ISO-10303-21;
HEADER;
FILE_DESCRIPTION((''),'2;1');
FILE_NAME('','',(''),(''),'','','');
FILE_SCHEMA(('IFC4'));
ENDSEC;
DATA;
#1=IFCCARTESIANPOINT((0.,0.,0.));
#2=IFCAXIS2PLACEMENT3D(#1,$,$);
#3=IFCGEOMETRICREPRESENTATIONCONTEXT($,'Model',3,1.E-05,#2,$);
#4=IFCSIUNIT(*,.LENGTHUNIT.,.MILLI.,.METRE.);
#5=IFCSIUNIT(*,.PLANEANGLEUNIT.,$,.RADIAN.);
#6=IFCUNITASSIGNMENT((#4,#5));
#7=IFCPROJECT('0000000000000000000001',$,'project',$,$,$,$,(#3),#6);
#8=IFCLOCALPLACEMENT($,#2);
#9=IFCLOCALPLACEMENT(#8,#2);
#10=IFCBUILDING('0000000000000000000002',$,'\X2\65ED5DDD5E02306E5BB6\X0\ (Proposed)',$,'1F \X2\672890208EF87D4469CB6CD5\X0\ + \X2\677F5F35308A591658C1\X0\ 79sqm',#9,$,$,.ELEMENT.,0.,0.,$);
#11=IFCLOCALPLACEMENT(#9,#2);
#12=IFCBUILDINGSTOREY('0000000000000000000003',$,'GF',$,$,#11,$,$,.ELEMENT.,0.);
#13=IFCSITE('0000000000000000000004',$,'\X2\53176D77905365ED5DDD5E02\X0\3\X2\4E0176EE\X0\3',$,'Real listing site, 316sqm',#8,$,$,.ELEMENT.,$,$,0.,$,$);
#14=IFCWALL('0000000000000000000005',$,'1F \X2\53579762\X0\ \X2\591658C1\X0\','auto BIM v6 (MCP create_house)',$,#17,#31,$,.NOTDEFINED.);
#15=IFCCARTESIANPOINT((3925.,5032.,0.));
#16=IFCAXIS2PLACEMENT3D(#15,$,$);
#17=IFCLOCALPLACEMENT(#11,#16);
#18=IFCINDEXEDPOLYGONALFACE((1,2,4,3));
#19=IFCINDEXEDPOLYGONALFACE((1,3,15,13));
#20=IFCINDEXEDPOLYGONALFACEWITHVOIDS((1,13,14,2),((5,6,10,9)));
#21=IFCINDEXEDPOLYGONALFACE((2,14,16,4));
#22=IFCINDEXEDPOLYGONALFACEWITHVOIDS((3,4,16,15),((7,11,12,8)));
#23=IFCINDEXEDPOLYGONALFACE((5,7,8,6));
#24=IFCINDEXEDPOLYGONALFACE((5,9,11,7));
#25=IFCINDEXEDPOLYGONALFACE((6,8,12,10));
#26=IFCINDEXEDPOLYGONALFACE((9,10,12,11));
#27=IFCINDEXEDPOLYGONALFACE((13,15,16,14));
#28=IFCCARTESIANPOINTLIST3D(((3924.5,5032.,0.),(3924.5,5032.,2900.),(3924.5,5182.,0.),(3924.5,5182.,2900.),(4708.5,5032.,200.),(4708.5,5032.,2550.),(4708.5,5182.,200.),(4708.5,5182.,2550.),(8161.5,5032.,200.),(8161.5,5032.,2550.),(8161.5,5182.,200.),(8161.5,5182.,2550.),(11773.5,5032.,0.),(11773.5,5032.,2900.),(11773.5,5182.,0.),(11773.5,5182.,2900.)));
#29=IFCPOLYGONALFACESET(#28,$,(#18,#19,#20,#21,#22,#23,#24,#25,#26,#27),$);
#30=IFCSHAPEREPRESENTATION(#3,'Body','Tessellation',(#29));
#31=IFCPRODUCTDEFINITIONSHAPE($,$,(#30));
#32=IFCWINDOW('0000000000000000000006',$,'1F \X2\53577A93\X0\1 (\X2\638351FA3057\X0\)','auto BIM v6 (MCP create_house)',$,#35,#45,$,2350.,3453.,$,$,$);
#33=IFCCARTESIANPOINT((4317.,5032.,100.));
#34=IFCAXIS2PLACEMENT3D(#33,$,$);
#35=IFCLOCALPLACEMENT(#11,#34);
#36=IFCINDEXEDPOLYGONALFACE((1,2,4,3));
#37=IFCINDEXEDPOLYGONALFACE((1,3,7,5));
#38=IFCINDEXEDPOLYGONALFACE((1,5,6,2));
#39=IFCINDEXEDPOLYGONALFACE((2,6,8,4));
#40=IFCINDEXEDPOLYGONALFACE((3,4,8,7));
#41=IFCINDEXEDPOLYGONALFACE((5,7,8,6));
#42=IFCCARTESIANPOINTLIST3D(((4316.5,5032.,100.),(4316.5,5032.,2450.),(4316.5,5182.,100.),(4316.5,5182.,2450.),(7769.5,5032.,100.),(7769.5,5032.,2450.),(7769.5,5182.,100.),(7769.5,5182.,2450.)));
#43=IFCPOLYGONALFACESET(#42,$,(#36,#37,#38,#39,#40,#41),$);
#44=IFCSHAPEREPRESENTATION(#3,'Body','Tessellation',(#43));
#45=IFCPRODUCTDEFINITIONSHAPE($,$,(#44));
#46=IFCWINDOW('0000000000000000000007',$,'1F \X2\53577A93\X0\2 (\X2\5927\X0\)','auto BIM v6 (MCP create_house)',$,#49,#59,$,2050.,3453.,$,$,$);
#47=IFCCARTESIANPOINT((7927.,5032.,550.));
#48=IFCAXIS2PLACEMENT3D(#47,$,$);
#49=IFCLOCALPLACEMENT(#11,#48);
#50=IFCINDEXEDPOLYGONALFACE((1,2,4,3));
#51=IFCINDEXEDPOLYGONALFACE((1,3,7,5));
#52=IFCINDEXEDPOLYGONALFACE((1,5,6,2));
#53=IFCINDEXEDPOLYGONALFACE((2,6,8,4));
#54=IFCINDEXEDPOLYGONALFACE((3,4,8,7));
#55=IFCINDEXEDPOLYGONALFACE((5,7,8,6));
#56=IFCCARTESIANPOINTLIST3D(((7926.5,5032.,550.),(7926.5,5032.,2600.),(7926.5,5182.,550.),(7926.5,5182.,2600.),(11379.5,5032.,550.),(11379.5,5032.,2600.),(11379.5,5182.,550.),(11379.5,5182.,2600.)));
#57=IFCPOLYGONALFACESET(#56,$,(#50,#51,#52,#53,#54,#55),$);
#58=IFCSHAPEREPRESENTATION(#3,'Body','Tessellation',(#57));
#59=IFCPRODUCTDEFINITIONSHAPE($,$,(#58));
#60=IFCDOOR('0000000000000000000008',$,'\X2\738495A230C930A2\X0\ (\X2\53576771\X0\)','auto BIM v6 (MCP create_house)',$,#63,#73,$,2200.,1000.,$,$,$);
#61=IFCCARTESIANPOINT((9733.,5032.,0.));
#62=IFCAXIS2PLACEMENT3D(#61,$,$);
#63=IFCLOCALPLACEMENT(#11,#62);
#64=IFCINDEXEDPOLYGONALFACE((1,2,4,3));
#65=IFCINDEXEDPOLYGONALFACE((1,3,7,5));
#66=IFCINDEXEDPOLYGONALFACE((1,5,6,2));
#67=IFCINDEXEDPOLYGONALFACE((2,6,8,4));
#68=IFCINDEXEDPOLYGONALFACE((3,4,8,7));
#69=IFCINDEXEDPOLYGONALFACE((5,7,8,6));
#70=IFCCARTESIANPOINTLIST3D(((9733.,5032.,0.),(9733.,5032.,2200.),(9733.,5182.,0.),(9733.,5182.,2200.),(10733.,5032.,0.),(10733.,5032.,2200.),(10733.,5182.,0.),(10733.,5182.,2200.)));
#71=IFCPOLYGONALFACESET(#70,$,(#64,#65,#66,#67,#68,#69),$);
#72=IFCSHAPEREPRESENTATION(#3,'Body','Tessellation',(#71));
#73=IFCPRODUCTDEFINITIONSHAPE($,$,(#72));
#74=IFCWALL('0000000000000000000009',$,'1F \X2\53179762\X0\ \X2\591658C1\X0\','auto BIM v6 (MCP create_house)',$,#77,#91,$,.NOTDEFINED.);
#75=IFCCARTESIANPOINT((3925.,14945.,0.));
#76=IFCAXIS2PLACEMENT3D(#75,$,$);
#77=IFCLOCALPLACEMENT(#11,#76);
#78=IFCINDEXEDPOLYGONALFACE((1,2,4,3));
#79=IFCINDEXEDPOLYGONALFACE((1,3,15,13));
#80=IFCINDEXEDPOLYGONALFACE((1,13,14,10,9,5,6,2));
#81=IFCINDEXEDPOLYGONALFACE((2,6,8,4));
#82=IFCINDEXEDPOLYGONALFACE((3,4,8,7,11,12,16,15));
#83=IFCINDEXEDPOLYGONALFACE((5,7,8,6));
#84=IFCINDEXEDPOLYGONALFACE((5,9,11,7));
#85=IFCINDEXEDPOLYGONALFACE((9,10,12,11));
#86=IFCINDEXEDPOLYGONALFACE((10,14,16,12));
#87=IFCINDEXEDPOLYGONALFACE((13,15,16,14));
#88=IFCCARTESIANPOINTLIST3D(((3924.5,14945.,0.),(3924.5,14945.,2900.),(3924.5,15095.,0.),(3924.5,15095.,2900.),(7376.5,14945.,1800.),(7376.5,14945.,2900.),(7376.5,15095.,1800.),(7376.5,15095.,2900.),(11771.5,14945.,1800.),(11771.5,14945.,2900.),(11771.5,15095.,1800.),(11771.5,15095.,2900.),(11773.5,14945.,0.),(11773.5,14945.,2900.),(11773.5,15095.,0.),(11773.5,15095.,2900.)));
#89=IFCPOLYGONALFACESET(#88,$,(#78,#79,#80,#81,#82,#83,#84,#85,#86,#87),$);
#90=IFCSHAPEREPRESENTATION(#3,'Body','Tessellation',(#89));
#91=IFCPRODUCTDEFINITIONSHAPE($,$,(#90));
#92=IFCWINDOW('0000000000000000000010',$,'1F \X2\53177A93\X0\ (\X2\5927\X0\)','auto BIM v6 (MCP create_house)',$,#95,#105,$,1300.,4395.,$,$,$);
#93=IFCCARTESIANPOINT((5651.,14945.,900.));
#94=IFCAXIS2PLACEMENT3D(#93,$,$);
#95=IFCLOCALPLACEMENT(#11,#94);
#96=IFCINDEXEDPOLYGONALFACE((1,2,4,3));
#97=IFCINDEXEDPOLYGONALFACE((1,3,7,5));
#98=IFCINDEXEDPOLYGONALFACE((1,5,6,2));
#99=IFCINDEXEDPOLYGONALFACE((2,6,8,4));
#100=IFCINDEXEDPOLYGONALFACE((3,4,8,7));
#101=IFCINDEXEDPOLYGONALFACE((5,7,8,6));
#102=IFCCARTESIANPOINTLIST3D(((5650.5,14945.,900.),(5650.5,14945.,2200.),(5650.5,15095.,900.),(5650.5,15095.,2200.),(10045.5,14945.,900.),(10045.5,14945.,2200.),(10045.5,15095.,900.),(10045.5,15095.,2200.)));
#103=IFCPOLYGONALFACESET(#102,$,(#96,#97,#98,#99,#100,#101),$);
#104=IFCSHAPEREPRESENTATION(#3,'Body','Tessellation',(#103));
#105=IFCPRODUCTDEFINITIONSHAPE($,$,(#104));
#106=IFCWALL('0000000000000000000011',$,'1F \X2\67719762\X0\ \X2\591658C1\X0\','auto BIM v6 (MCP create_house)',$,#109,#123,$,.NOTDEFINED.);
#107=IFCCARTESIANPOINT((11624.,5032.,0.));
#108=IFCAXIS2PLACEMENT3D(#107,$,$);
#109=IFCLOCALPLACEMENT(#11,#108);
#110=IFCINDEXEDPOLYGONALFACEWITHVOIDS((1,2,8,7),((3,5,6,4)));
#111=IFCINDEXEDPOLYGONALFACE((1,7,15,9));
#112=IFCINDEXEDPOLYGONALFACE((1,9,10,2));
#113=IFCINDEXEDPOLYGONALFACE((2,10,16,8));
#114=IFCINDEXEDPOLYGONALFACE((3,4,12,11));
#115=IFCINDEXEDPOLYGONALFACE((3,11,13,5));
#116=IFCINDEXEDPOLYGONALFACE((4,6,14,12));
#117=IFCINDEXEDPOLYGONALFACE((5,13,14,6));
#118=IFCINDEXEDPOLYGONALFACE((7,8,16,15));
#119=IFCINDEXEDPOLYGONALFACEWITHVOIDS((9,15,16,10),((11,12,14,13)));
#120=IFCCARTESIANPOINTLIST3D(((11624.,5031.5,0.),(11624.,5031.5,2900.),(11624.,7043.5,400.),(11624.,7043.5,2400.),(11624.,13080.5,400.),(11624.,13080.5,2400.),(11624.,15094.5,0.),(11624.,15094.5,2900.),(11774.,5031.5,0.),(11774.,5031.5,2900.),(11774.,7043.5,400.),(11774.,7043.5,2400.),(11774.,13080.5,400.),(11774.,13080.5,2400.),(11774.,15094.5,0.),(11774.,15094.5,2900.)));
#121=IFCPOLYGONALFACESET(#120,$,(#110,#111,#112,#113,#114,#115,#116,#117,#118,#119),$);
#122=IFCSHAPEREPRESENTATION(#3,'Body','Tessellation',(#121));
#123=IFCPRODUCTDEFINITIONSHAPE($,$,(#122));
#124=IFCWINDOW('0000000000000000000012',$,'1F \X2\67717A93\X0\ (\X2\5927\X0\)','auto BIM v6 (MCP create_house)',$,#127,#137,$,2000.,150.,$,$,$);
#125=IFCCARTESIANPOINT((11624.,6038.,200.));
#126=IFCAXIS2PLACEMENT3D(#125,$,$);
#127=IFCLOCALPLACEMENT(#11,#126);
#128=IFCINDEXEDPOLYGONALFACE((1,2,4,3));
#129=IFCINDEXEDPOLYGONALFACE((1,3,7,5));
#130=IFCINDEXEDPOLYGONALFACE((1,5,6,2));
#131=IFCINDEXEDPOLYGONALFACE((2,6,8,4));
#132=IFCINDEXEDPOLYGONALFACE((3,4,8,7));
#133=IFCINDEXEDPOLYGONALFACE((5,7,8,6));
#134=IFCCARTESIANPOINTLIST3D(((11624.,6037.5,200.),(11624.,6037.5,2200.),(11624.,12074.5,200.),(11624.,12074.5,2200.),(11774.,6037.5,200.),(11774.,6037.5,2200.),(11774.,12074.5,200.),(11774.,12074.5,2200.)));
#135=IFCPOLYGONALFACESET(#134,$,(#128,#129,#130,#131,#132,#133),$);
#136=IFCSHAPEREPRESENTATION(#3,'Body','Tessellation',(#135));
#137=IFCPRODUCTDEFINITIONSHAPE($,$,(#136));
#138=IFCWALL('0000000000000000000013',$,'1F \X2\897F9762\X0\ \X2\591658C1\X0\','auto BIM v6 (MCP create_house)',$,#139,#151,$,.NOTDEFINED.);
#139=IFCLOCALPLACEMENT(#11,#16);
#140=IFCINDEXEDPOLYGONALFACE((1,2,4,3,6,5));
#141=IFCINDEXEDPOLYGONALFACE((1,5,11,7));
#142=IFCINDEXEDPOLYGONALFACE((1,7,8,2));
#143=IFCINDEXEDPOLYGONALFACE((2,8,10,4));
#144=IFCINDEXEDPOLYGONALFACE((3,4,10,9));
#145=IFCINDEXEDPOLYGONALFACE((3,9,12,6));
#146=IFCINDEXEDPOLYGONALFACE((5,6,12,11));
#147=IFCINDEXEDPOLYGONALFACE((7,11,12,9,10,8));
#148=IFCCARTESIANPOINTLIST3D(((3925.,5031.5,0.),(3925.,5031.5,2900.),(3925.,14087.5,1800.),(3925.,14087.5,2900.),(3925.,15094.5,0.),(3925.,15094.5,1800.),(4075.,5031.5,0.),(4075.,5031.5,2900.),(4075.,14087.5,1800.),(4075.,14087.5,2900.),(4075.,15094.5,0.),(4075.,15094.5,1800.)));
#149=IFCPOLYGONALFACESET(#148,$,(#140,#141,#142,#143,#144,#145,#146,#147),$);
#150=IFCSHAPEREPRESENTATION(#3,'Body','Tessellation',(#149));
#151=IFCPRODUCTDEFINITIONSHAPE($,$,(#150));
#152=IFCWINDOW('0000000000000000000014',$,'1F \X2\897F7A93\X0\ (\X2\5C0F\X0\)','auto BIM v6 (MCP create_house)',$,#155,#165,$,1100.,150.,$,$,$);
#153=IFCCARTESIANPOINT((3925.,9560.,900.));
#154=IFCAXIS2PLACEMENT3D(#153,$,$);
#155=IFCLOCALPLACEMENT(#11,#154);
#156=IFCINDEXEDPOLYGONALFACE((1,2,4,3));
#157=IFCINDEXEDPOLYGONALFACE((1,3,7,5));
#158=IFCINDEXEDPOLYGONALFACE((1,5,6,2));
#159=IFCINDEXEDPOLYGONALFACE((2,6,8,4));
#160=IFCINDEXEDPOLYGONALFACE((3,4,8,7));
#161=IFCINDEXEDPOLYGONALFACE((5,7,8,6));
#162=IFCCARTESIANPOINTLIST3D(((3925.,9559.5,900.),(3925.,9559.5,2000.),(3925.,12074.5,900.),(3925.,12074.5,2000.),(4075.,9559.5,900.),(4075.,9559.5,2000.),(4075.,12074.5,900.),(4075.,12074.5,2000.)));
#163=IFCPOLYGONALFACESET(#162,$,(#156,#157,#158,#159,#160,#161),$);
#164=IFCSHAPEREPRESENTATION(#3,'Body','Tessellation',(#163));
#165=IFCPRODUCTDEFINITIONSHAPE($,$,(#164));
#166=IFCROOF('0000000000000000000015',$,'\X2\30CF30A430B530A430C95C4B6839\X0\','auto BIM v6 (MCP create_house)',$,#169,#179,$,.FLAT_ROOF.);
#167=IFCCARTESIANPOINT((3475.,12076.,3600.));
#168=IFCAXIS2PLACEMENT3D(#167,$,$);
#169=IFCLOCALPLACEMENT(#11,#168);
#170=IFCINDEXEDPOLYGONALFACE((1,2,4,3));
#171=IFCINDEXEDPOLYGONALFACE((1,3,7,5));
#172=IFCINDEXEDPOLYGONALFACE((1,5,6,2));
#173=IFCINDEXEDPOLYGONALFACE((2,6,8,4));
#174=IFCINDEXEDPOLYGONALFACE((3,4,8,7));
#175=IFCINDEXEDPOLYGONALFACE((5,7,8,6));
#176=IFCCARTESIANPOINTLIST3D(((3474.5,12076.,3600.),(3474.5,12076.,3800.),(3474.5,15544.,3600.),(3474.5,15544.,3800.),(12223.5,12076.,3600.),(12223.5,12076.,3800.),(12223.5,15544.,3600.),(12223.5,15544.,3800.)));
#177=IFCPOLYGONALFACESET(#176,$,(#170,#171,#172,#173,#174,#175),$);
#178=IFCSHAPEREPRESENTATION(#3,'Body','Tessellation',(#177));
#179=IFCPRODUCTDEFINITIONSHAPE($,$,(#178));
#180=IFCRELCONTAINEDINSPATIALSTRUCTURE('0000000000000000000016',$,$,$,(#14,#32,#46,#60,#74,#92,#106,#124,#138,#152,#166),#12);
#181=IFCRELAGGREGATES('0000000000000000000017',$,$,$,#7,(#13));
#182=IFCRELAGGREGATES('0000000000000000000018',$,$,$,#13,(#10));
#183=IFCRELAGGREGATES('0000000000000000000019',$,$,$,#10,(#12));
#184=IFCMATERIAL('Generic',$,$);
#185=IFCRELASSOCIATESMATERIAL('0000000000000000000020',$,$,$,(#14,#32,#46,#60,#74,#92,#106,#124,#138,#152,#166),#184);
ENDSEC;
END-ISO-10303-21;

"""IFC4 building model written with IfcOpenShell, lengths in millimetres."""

from ifc_helpers import new_model, si_unit, frame, frame_2d, origin, place, context, project, spatial, rectangle, extrude, material, element, fill, save


model = new_model("IFC4")

# Units and contexts
model_context = context("Model", 3, precision=1e-05, world=origin())
ifc_project = project(units=[si_unit("LENGTHUNIT", "METRE", prefix="MILLI"), si_unit("PLANEANGLEUNIT", "RADIAN")], contexts=[model_context])

# Site, building, storey
site_placement = place(None, origin())
site = spatial("IfcSite", under=ifc_project, at=site_placement, Name="北海道旭川市3丁目3", ObjectType="Real listing site, 316sqm", CompositionType="ELEMENT", RefElevation=0.0)
building_placement = place(site_placement, origin())
building = spatial("IfcBuilding", under=site, at=building_placement, Name="旭川市の家 (Proposed)", ObjectType="1F 木造軸組構法 + 板張り外壁 79sqm", CompositionType="ELEMENT", ElevationOfRefHeight=0.0, ElevationOfTerrain=0.0)
storey_placement = place(building_placement, origin())
storey = spatial("IfcBuildingStorey", under=building, at=storey_placement, Name="GF", CompositionType="ELEMENT", Elevation=0.0)

# Shared definitions
ifc_material = material(Name="Generic")

# Wall, openings, windows, door
wall_1_placement = place(storey_placement, frame((3925.0, 5032.0, 0.0)))
wall_1 = element("IfcWall", 1, at=wall_1_placement, inside=storey, material=ifc_material, Name="1F 南面 外壁", Description="auto BIM v6 (MCP create_house)", PredefinedType="NOTDEFINED", context=model_context, shape_type="SweptSolid", body=[
    extrude(rectangle(XDim=7849.0, YDim=150.0, at=frame_2d((3924.0, 75.0))), frame((3925.0, 5032.0, 0.0)), (0.0, 0.0, 1.0), 2900.0),
])
opening_1_placement = place(storey_placement, frame((4317.0, 5032.0, 100.0)))
opening_1 = element("IfcOpeningElement", 2, at=opening_1_placement, cuts=wall_1, PredefinedType="NOTDEFINED", context=model_context, shape_type="SweptSolid", body=[
    extrude(rectangle(XDim=3453.0, YDim=150.0, at=frame_2d((1726.0, 75.0))), frame((4317.0, 5032.0, 100.0)), (0.0, 0.0, 1.0), 2350.0),
])
opening_2_placement = place(storey_placement, frame((7927.0, 5032.0, 550.0)))
opening_2 = element("IfcOpeningElement", 3, at=opening_2_placement, cuts=wall_1, PredefinedType="NOTDEFINED", context=model_context, shape_type="SweptSolid", body=[
    extrude(rectangle(XDim=3453.0, YDim=150.0, at=frame_2d((1726.0, 75.0))), frame((7927.0, 5032.0, 550.0)), (0.0, 0.0, 1.0), 2050.0),
])
opening_3_placement = place(storey_placement, frame((9733.0, 5032.0, 0.0)))
opening_3 = element("IfcOpeningElement", 4, at=opening_3_placement, cuts=wall_1, PredefinedType="NOTDEFINED", context=model_context, shape_type="SweptSolid", body=[
    extrude(rectangle(XDim=1000.0, YDim=150.0, at=frame_2d((500.0, 75.0))), frame((9733.0, 5032.0, 0.0)), (0.0, 0.0, 1.0), 2200.0),
])
window_1_placement = place(storey_placement, frame((4317.0, 5032.0, 100.0)))
window_1 = element("IfcWindow", 5, at=window_1_placement, inside=storey, material=ifc_material, Name="1F 南窓1 (掃出し)", Description="auto BIM v6 (MCP create_house)", OverallHeight=2350.0, OverallWidth=3453.0, context=model_context, shape_type="SweptSolid", body=[
    extrude(rectangle(XDim=3453.0, YDim=150.0, at=frame_2d((1726.0, 75.0))), frame((4317.0, 5032.0, 100.0)), (0.0, 0.0, 1.0), 2350.0),
])
fill(opening_1, window_1)
window_2_placement = place(storey_placement, frame((7927.0, 5032.0, 550.0)))
window_2 = element("IfcWindow", 6, at=window_2_placement, inside=storey, material=ifc_material, Name="1F 南窓2 (大)", Description="auto BIM v6 (MCP create_house)", OverallHeight=2050.0, OverallWidth=3453.0, context=model_context, shape_type="SweptSolid", body=[
    extrude(rectangle(XDim=3453.0, YDim=150.0, at=frame_2d((1726.0, 75.0))), frame((7927.0, 5032.0, 550.0)), (0.0, 0.0, 1.0), 2050.0),
])
fill(opening_2, window_2)
door_placement = place(storey_placement, frame((9733.0, 5032.0, 0.0)))
door = element("IfcDoor", 7, at=door_placement, inside=storey, material=ifc_material, Name="玄関ドア (南東)", Description="auto BIM v6 (MCP create_house)", OverallHeight=2200.0, OverallWidth=1000.0, context=model_context, shape_type="SweptSolid", body=[
    extrude(rectangle(XDim=1000.0, YDim=150.0, at=frame_2d((500.0, 75.0))), frame((9733.0, 5032.0, 0.0)), (0.0, 0.0, 1.0), 2200.0),
])
fill(opening_3, door)

# Walls, openings, windows
wall_2_placement = place(storey_placement, frame((3925.0, 14945.0, 0.0)))
wall_2 = element("IfcWall", 8, at=wall_2_placement, inside=storey, material=ifc_material, Name="1F 北面 外壁", Description="auto BIM v6 (MCP create_house)", PredefinedType="NOTDEFINED", context=model_context, shape_type="SweptSolid", body=[
    extrude(rectangle(XDim=7849.0, YDim=150.0, at=frame_2d((3924.0, 75.0))), frame((3925.0, 14945.0, 0.0)), (0.0, 0.0, 1.0), 2900.0),
])
opening_4_placement = place(storey_placement, frame((5651.0, 14945.0, 900.0)))
opening_4 = element("IfcOpeningElement", 9, at=opening_4_placement, cuts=wall_2, PredefinedType="NOTDEFINED", context=model_context, shape_type="SweptSolid", body=[
    extrude(rectangle(XDim=4395.0, YDim=150.0, at=frame_2d((2197.0, 75.0))), frame((5651.0, 14945.0, 900.0)), (0.0, 0.0, 1.0), 1300.0),
])
window_3_placement = place(storey_placement, frame((5651.0, 14945.0, 900.0)))
window_3 = element("IfcWindow", 10, at=window_3_placement, inside=storey, material=ifc_material, Name="1F 北窓 (大)", Description="auto BIM v6 (MCP create_house)", OverallHeight=1300.0, OverallWidth=4395.0, context=model_context, shape_type="SweptSolid", body=[
    extrude(rectangle(XDim=4395.0, YDim=150.0, at=frame_2d((2197.0, 75.0))), frame((5651.0, 14945.0, 900.0)), (0.0, 0.0, 1.0), 1300.0),
])
fill(opening_4, window_3)
wall_3_placement = place(storey_placement, frame((11624.0, 5032.0, 0.0)))
wall_3 = element("IfcWall", 11, at=wall_3_placement, inside=storey, material=ifc_material, Name="1F 東面 外壁", Description="auto BIM v6 (MCP create_house)", PredefinedType="NOTDEFINED", context=model_context, shape_type="SweptSolid", body=[
    extrude(rectangle(XDim=150.0, YDim=10063.0, at=frame_2d((75.0, 5031.0))), frame((11624.0, 5032.0, 0.0)), (0.0, 0.0, 1.0), 2900.0),
])
opening_5_placement = place(storey_placement, frame((11624.0, 6038.0, 200.0)))
opening_5 = element("IfcOpeningElement", 12, at=opening_5_placement, cuts=wall_3, PredefinedType="NOTDEFINED", context=model_context, shape_type="SweptSolid", body=[
    extrude(rectangle(XDim=150.0, YDim=6037.0, at=frame_2d((75.0, 3018.0))), frame((11624.0, 6038.0, 200.0)), (0.0, 0.0, 1.0), 2000.0),
])
window_4_placement = place(storey_placement, frame((11624.0, 6038.0, 200.0)))
window_4 = element("IfcWindow", 13, at=window_4_placement, inside=storey, material=ifc_material, Name="1F 東窓 (大)", Description="auto BIM v6 (MCP create_house)", OverallHeight=2000.0, OverallWidth=150.0, context=model_context, shape_type="SweptSolid", body=[
    extrude(rectangle(XDim=150.0, YDim=6037.0, at=frame_2d((75.0, 3018.0))), frame((11624.0, 6038.0, 200.0)), (0.0, 0.0, 1.0), 2000.0),
])
fill(opening_5, window_4)
wall_4_placement = place(storey_placement, frame((3925.0, 5032.0, 0.0)))
wall_4 = element("IfcWall", 14, at=wall_4_placement, inside=storey, material=ifc_material, Name="1F 西面 外壁", Description="auto BIM v6 (MCP create_house)", PredefinedType="NOTDEFINED", context=model_context, shape_type="SweptSolid", body=[
    extrude(rectangle(XDim=150.0, YDim=10063.0, at=frame_2d((75.0, 5031.0))), frame((3925.0, 5032.0, 0.0)), (0.0, 0.0, 1.0), 2900.0),
])
opening_6_placement = place(storey_placement, frame((3925.0, 9560.0, 900.0)))
opening_6 = element("IfcOpeningElement", 15, at=opening_6_placement, cuts=wall_4, PredefinedType="NOTDEFINED", context=model_context, shape_type="SweptSolid", body=[
    extrude(rectangle(XDim=150.0, YDim=2515.0, at=frame_2d((75.0, 1257.0))), frame((3925.0, 9560.0, 900.0)), (0.0, 0.0, 1.0), 1100.0),
])
window_5_placement = place(storey_placement, frame((3925.0, 9560.0, 900.0)))
window_5 = element("IfcWindow", 16, at=window_5_placement, inside=storey, material=ifc_material, Name="1F 西窓 (小)", Description="auto BIM v6 (MCP create_house)", OverallHeight=1100.0, OverallWidth=150.0, context=model_context, shape_type="SweptSolid", body=[
    extrude(rectangle(XDim=150.0, YDim=2515.0, at=frame_2d((75.0, 1257.0))), frame((3925.0, 9560.0, 900.0)), (0.0, 0.0, 1.0), 1100.0),
])
fill(opening_6, window_5)

# Roof
roof_1_placement = place(storey_placement, frame((3475.0, 12076.0, 3600.0)))
element("IfcRoof", 17, at=roof_1_placement, inside=storey, material=ifc_material, Name="ハイサイド屋根", Description="auto BIM v6 (MCP create_house)", PredefinedType="FLAT_ROOF", context=model_context, shape_type="SweptSolid", body=[
    extrude(rectangle(XDim=8749.0, YDim=3468.0, at=frame_2d((4374.0, 1734.0))), frame((3475.0, 12076.0, 3600.0)), (0.0, 0.0, 1.0), 200.0),
])

save(model, "model.ifc")
